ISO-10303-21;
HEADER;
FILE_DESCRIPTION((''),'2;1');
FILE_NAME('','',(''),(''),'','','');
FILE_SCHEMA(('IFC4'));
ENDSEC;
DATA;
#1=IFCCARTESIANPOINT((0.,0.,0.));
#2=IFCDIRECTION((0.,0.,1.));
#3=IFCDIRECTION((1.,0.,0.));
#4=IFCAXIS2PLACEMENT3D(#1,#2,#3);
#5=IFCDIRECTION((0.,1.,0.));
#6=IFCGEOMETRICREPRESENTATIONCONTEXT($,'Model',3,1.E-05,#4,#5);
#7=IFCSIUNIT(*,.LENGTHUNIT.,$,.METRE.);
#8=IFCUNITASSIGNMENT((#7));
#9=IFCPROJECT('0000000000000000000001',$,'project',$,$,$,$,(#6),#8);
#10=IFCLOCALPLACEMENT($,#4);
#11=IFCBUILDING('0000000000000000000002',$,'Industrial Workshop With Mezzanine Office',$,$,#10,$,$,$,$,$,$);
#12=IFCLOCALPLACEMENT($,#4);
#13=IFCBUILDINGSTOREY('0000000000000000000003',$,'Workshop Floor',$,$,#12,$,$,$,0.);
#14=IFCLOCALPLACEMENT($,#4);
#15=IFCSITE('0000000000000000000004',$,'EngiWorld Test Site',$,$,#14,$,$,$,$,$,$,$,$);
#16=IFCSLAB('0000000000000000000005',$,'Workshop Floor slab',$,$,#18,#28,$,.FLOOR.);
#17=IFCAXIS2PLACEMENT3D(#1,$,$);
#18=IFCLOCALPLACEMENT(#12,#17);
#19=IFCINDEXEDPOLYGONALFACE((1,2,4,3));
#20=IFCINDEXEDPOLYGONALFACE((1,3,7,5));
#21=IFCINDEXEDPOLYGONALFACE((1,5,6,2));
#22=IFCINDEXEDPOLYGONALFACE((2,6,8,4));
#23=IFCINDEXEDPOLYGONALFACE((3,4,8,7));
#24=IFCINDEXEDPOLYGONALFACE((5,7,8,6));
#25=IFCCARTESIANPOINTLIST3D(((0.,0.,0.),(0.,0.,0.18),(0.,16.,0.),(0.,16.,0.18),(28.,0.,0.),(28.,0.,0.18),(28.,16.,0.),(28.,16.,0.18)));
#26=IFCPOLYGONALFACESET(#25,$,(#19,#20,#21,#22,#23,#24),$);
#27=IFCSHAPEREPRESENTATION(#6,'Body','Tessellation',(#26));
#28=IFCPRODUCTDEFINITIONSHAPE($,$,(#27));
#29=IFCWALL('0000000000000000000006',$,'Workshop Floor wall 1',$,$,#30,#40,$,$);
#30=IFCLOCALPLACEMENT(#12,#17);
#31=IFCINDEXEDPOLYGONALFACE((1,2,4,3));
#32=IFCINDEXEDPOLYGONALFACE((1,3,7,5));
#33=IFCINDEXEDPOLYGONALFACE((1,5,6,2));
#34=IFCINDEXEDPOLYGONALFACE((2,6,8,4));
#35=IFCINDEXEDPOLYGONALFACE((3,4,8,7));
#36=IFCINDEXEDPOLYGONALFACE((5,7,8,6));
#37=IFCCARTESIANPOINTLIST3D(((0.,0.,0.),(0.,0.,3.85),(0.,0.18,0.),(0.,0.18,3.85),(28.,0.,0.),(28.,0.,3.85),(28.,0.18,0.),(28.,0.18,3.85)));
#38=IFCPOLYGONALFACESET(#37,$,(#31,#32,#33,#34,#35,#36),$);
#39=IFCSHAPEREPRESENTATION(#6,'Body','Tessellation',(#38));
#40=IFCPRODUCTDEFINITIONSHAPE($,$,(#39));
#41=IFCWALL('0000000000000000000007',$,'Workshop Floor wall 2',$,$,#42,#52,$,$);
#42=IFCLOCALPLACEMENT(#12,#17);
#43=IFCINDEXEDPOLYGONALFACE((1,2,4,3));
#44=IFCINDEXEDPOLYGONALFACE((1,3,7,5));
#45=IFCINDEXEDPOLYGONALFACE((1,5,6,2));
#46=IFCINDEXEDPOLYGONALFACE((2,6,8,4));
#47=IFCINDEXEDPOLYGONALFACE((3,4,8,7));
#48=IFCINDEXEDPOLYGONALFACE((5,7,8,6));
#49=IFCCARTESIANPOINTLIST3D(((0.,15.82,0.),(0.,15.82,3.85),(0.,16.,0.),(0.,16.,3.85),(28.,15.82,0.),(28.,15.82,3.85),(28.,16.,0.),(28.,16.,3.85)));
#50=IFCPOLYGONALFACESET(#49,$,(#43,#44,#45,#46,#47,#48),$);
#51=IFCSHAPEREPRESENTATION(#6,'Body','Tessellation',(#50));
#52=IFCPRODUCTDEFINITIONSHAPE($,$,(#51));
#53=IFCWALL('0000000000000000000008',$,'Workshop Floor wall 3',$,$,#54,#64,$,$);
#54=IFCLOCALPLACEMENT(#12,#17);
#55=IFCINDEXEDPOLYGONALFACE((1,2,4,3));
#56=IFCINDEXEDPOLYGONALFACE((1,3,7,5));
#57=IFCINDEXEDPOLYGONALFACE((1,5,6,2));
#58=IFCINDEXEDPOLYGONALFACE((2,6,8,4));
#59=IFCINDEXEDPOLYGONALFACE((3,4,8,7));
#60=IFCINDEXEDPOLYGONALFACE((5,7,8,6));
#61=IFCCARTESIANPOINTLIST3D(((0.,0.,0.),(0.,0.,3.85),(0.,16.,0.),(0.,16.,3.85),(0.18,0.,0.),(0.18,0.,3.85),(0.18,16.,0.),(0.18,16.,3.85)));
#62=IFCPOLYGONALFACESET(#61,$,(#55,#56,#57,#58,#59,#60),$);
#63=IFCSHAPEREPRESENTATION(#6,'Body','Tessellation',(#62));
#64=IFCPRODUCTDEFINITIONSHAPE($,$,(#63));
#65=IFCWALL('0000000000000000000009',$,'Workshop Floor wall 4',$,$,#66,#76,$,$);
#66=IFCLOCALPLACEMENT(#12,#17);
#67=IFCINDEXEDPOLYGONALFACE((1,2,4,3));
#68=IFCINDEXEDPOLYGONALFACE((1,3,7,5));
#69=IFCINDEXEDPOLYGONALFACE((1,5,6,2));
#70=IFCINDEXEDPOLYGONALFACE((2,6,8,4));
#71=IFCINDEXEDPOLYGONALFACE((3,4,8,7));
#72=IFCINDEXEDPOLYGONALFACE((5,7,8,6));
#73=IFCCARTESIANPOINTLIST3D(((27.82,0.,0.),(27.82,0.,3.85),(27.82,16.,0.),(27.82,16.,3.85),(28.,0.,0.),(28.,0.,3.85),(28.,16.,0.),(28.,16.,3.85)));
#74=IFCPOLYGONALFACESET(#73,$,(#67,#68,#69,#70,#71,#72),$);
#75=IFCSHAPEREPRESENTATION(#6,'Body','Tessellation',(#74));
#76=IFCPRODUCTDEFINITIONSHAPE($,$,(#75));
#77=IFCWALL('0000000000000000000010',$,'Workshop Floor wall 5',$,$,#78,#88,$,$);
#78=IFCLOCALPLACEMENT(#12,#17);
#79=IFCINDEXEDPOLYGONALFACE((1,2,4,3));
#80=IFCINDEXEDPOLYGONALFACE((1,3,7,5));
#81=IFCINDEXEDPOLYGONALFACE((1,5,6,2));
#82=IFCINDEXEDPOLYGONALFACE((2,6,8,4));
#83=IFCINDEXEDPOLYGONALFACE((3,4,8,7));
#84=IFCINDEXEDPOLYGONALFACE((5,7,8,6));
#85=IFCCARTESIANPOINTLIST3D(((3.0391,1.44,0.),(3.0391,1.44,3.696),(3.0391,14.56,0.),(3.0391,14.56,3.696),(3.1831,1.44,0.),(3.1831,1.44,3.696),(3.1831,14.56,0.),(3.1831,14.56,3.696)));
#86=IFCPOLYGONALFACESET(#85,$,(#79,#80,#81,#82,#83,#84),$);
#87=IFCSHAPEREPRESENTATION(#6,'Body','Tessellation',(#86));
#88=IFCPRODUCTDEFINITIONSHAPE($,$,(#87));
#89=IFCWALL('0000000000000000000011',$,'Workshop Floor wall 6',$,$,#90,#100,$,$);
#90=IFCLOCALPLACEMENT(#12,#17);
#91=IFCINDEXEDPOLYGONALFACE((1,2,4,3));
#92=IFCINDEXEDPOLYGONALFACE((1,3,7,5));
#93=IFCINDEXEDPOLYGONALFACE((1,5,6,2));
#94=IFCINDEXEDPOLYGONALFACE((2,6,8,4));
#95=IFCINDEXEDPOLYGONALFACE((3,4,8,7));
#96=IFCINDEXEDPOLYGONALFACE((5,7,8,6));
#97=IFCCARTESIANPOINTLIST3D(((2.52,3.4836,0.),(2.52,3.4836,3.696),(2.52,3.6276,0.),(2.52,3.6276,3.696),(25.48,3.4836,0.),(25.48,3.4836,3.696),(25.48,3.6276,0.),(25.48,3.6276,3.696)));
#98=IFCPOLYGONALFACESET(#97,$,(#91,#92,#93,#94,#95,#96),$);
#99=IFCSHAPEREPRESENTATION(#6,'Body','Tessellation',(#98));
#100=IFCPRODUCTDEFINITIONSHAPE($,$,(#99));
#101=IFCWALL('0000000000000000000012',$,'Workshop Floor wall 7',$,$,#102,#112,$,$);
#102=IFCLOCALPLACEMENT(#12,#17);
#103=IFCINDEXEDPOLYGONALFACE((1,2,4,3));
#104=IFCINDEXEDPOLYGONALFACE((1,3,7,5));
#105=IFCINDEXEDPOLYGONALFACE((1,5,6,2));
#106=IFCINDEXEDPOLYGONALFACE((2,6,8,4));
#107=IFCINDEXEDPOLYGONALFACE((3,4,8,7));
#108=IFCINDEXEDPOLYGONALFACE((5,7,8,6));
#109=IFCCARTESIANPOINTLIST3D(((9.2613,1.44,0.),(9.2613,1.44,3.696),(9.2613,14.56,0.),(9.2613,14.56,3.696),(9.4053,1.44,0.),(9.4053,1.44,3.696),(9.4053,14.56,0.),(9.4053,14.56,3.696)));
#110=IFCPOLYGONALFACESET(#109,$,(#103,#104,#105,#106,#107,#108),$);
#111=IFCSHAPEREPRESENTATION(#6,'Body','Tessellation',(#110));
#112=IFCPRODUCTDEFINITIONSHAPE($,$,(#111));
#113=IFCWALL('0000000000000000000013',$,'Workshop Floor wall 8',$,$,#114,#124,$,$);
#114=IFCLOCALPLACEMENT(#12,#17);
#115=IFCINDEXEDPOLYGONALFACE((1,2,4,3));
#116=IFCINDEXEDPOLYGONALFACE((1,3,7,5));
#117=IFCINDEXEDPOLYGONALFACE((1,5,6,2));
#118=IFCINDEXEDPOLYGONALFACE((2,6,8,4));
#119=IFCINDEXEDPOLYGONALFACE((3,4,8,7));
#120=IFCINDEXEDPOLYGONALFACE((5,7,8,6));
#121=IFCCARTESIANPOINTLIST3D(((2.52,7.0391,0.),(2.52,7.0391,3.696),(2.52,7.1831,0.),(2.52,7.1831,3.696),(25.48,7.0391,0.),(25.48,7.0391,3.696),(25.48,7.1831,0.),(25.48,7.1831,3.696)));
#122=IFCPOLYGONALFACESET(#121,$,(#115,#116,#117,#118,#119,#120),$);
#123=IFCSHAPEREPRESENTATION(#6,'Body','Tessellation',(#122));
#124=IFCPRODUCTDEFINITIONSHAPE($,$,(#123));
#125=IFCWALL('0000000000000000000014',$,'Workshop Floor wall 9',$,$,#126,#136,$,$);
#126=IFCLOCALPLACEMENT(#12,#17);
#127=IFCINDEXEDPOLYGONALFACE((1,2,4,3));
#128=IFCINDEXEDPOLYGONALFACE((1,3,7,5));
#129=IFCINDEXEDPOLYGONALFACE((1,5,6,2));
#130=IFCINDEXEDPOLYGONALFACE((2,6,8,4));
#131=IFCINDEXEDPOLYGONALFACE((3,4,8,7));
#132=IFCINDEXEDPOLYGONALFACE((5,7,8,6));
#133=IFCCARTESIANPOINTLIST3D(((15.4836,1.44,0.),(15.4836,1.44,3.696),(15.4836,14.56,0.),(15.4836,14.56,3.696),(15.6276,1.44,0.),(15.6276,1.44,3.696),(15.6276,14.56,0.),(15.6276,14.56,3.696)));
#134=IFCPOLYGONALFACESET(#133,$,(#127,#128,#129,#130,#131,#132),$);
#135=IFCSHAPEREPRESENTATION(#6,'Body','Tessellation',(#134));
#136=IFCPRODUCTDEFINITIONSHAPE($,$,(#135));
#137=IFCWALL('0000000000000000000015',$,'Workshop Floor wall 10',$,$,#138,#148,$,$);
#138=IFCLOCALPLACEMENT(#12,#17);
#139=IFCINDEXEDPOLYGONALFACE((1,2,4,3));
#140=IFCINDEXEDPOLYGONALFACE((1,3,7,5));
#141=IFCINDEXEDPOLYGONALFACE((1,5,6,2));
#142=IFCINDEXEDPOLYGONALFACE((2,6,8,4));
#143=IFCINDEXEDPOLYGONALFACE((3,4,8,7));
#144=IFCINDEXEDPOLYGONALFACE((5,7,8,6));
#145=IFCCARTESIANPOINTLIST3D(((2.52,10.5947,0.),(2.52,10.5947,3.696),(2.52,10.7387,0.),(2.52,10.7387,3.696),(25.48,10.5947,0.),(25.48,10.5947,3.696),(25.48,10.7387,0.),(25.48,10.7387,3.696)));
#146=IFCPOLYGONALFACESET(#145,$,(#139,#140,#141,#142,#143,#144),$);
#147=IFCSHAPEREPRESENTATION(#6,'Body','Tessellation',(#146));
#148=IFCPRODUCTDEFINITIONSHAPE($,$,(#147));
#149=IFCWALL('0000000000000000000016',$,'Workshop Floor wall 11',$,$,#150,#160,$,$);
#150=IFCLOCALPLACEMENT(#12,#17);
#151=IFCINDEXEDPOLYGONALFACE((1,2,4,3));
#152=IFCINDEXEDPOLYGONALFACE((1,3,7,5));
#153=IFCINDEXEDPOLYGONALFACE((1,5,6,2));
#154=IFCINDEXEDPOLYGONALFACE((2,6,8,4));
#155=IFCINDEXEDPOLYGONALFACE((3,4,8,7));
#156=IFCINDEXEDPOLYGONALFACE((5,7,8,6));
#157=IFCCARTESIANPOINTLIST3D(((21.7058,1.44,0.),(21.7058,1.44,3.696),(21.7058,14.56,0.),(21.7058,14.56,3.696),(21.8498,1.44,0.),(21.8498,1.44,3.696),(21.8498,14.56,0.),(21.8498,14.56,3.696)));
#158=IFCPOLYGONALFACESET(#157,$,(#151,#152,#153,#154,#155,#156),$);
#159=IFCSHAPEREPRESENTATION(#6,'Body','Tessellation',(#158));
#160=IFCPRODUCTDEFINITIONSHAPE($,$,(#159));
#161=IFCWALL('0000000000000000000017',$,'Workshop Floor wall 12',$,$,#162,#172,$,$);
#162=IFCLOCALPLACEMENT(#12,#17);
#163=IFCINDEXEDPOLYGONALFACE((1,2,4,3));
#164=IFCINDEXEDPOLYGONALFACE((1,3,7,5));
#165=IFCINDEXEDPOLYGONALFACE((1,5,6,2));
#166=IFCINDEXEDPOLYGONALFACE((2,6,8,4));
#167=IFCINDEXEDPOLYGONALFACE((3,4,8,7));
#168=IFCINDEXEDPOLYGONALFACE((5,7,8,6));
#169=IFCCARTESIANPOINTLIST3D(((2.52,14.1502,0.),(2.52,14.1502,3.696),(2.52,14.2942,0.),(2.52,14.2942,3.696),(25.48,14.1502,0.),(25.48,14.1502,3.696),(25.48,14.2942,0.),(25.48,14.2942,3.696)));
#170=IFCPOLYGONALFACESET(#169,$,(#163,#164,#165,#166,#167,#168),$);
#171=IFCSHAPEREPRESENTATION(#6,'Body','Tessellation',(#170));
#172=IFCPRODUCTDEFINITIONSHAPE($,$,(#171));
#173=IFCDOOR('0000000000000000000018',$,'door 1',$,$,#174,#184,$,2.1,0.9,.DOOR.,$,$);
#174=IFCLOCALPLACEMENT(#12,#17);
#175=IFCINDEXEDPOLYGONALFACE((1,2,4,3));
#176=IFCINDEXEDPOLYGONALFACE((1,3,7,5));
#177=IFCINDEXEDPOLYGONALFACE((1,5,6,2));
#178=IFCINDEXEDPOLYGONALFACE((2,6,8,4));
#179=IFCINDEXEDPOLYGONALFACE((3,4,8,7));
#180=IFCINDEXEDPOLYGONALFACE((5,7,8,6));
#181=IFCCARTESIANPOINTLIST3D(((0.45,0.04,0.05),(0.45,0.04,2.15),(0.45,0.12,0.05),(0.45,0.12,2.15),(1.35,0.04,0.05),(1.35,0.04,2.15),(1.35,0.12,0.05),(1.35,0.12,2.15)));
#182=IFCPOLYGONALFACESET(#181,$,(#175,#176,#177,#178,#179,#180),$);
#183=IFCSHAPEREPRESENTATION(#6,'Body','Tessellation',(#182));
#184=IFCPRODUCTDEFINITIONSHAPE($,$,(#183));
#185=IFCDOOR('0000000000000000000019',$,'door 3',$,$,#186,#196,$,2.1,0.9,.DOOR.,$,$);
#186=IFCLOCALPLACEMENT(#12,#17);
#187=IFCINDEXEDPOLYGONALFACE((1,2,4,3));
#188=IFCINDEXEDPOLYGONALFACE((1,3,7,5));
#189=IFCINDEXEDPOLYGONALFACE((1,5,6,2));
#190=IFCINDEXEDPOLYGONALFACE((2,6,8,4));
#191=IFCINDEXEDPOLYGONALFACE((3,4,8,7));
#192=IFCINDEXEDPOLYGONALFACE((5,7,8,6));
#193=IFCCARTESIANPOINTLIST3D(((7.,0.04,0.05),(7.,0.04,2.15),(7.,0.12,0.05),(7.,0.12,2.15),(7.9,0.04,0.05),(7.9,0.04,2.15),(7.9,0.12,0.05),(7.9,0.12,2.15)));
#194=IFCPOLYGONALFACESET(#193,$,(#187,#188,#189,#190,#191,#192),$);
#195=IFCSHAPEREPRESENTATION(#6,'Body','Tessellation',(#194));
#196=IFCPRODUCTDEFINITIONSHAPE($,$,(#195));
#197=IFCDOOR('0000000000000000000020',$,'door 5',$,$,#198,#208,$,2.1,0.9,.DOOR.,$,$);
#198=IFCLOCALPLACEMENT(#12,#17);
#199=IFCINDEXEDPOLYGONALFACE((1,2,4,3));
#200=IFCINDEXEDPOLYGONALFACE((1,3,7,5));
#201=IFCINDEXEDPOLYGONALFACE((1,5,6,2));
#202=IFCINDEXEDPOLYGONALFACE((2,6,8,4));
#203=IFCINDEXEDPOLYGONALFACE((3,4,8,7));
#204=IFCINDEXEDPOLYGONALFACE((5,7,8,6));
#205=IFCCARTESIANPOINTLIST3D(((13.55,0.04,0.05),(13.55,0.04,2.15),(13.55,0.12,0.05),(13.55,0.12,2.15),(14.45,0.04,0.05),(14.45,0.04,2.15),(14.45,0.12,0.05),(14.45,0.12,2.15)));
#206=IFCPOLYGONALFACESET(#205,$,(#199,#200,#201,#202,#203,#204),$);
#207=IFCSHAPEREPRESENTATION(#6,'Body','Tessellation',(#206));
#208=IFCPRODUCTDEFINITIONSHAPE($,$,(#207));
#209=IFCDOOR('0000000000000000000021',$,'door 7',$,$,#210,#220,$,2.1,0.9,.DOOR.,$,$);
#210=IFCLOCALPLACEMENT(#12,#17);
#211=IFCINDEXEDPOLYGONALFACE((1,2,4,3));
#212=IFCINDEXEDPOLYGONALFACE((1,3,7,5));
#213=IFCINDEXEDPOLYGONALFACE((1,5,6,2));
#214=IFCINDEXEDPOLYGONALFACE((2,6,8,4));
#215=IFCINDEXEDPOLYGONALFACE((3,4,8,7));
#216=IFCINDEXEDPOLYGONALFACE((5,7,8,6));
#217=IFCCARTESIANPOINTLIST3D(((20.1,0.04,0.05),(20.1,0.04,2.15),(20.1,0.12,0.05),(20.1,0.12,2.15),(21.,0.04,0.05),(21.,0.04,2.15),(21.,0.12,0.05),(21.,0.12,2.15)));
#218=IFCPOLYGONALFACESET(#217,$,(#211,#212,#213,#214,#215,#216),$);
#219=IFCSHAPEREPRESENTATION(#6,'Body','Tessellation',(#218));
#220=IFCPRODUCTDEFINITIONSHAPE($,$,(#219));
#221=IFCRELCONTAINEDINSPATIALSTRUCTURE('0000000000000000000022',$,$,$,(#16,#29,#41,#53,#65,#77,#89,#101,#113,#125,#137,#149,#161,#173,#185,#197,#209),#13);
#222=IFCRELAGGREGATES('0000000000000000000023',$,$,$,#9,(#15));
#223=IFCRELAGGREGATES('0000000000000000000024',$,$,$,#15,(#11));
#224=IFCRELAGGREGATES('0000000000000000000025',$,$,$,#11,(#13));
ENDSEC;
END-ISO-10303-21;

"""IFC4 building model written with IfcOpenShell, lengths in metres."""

from ifc_helpers import new_model, si_unit, direction, frame, origin_with_axes, origin_2d_with_axis, place, context, project, spatial, rectangle, extrude, element, save


model = new_model("IFC4")

# Units and contexts
model_context = context("Model", 3, precision=1e-05, world=origin_with_axes(), true_north=direction((0.0, 1.0, 0.0)))
ifc_project = project(units=[si_unit("LENGTHUNIT", "METRE")], contexts=[model_context])

# Site, building, storey
site_placement = place(None, origin_with_axes())
site = spatial("IfcSite", under=ifc_project, at=site_placement, Name="EngiWorld Test Site")
building_placement = place(None, origin_with_axes())
building = spatial("IfcBuilding", under=site, at=building_placement, Name="Industrial Workshop With Mezzanine Office")
storey_placement = place(None, origin_with_axes())
storey = spatial("IfcBuildingStorey", under=building, at=storey_placement, Name="Workshop Floor", Elevation=0.0)

# Slab
slab_placement = place(None, frame((14.0, 8.0, 0.0), z_axis=(0.0, 0.0, 1.0), x_axis=(1.0, 0.0, 0.0)))
element("IfcSlab", 1, at=slab_placement, inside=storey, Name="Workshop Floor slab", PredefinedType="FLOOR", context=model_context, shape_type="SweptSolid", body=[
    extrude(rectangle(XDim=28.0, YDim=16.0, at=origin_2d_with_axis()), origin_with_axes(), (0.0, 0.0, 1.0), 0.18),
])

# Walls
for number, where, z_axis, x_axis, name in (
    (2, (14.0, 0.09, 0.0), (0.0, 0.0, 1.0), (1.0, 0.0, 0.0), "Workshop Floor wall 1"),
    (3, (14.0, 15.91, 0.0), (0.0, 0.0, 1.0), (1.0, 0.0, 0.0), "Workshop Floor wall 2"),
):
    element("IfcWall", number, at=place(None, frame(where, z_axis=z_axis, x_axis=x_axis)), inside=storey, Name=name, context=model_context, shape_type="SweptSolid", body=[
        extrude(rectangle(XDim=28.0, YDim=0.18, at=origin_2d_with_axis()), origin_with_axes(), (0.0, 0.0, 1.0), 3.85),
    ])
for number, where, z_axis, x_axis, name in (
    (4, (0.09, 8.0, 0.0), (0.0, 0.0, 1.0), (1.0, 0.0, 0.0), "Workshop Floor wall 3"),
    (5, (27.91, 8.0, 0.0), (0.0, 0.0, 1.0), (1.0, 0.0, 0.0), "Workshop Floor wall 4"),
):
    element("IfcWall", number, at=place(None, frame(where, z_axis=z_axis, x_axis=x_axis)), inside=storey, Name=name, context=model_context, shape_type="SweptSolid", body=[
        extrude(rectangle(XDim=0.18, YDim=16.0, at=origin_2d_with_axis()), origin_with_axes(), (0.0, 0.0, 1.0), 3.85),
    ])
wall_1_placement = place(None, frame((3.1111, 8.0, 0.0), z_axis=(0.0, 0.0, 1.0), x_axis=(1.0, 0.0, 0.0)))
element("IfcWall", 6, at=wall_1_placement, inside=storey, Name="Workshop Floor wall 5", context=model_context, shape_type="SweptSolid", body=[
    extrude(rectangle(XDim=0.144, YDim=13.12, at=origin_2d_with_axis()), origin_with_axes(), (0.0, 0.0, 1.0), 3.696),
])
wall_2_placement = place(None, frame((14.0, 3.5556, 0.0), z_axis=(0.0, 0.0, 1.0), x_axis=(1.0, 0.0, 0.0)))
element("IfcWall", 7, at=wall_2_placement, inside=storey, Name="Workshop Floor wall 6", context=model_context, shape_type="SweptSolid", body=[
    extrude(rectangle(XDim=22.96, YDim=0.144, at=origin_2d_with_axis()), origin_with_axes(), (0.0, 0.0, 1.0), 3.696),
])
wall_3_placement = place(None, frame((9.3333, 8.0, 0.0), z_axis=(0.0, 0.0, 1.0), x_axis=(1.0, 0.0, 0.0)))
element("IfcWall", 8, at=wall_3_placement, inside=storey, Name="Workshop Floor wall 7", context=model_context, shape_type="SweptSolid", body=[
    extrude(rectangle(XDim=0.144, YDim=13.12, at=origin_2d_with_axis()), origin_with_axes(), (0.0, 0.0, 1.0), 3.696),
])
wall_4_placement = place(None, frame((14.0, 7.1111, 0.0), z_axis=(0.0, 0.0, 1.0), x_axis=(1.0, 0.0, 0.0)))
element("IfcWall", 9, at=wall_4_placement, inside=storey, Name="Workshop Floor wall 8", context=model_context, shape_type="SweptSolid", body=[
    extrude(rectangle(XDim=22.96, YDim=0.144, at=origin_2d_with_axis()), origin_with_axes(), (0.0, 0.0, 1.0), 3.696),
])
wall_5_placement = place(None, frame((15.5556, 8.0, 0.0), z_axis=(0.0, 0.0, 1.0), x_axis=(1.0, 0.0, 0.0)))
element("IfcWall", 10, at=wall_5_placement, inside=storey, Name="Workshop Floor wall 9", context=model_context, shape_type="SweptSolid", body=[
    extrude(rectangle(XDim=0.144, YDim=13.12, at=origin_2d_with_axis()), origin_with_axes(), (0.0, 0.0, 1.0), 3.696),
])
wall_6_placement = place(None, frame((14.0, 10.6667, 0.0), z_axis=(0.0, 0.0, 1.0), x_axis=(1.0, 0.0, 0.0)))
element("IfcWall", 11, at=wall_6_placement, inside=storey, Name="Workshop Floor wall 10", context=model_context, shape_type="SweptSolid", body=[
    extrude(rectangle(XDim=22.96, YDim=0.144, at=origin_2d_with_axis()), origin_with_axes(), (0.0, 0.0, 1.0), 3.696),
])
wall_7_placement = place(None, frame((21.7778, 8.0, 0.0), z_axis=(0.0, 0.0, 1.0), x_axis=(1.0, 0.0, 0.0)))
element("IfcWall", 12, at=wall_7_placement, inside=storey, Name="Workshop Floor wall 11", context=model_context, shape_type="SweptSolid", body=[
    extrude(rectangle(XDim=0.144, YDim=13.12, at=origin_2d_with_axis()), origin_with_axes(), (0.0, 0.0, 1.0), 3.696),
])
wall_8_placement = place(None, frame((14.0, 14.2222, 0.0), z_axis=(0.0, 0.0, 1.0), x_axis=(1.0, 0.0, 0.0)))
element("IfcWall", 13, at=wall_8_placement, inside=storey, Name="Workshop Floor wall 12", context=model_context, shape_type="SweptSolid", body=[
    extrude(rectangle(XDim=22.96, YDim=0.144, at=origin_2d_with_axis()), origin_with_axes(), (0.0, 0.0, 1.0), 3.696),
])

# Doors
for number, where, z_axis, x_axis, name in (
    (14, (0.9, 0.08, 0.05), (0.0, 0.0, 1.0), (1.0, 0.0, 0.0), "door 1"),
    (15, (7.45, 0.08, 0.05), (0.0, 0.0, 1.0), (1.0, 0.0, 0.0), "door 3"),
    (16, (14.0, 0.08, 0.05), (0.0, 0.0, 1.0), (1.0, 0.0, 0.0), "door 5"),
    (17, (20.55, 0.08, 0.05), (0.0, 0.0, 1.0), (1.0, 0.0, 0.0), "door 7"),
):
    element("IfcDoor", number, at=place(None, frame(where, z_axis=z_axis, x_axis=x_axis)), inside=storey, Name=name, OverallHeight=2.1, OverallWidth=0.9, PredefinedType="DOOR", context=model_context, shape_type="SweptSolid", body=[
        extrude(rectangle(XDim=0.9, YDim=0.08, at=origin_2d_with_axis()), origin_with_axes(), (0.0, 0.0, 1.0), 2.1),
    ])

save(model, "model.ifc")
